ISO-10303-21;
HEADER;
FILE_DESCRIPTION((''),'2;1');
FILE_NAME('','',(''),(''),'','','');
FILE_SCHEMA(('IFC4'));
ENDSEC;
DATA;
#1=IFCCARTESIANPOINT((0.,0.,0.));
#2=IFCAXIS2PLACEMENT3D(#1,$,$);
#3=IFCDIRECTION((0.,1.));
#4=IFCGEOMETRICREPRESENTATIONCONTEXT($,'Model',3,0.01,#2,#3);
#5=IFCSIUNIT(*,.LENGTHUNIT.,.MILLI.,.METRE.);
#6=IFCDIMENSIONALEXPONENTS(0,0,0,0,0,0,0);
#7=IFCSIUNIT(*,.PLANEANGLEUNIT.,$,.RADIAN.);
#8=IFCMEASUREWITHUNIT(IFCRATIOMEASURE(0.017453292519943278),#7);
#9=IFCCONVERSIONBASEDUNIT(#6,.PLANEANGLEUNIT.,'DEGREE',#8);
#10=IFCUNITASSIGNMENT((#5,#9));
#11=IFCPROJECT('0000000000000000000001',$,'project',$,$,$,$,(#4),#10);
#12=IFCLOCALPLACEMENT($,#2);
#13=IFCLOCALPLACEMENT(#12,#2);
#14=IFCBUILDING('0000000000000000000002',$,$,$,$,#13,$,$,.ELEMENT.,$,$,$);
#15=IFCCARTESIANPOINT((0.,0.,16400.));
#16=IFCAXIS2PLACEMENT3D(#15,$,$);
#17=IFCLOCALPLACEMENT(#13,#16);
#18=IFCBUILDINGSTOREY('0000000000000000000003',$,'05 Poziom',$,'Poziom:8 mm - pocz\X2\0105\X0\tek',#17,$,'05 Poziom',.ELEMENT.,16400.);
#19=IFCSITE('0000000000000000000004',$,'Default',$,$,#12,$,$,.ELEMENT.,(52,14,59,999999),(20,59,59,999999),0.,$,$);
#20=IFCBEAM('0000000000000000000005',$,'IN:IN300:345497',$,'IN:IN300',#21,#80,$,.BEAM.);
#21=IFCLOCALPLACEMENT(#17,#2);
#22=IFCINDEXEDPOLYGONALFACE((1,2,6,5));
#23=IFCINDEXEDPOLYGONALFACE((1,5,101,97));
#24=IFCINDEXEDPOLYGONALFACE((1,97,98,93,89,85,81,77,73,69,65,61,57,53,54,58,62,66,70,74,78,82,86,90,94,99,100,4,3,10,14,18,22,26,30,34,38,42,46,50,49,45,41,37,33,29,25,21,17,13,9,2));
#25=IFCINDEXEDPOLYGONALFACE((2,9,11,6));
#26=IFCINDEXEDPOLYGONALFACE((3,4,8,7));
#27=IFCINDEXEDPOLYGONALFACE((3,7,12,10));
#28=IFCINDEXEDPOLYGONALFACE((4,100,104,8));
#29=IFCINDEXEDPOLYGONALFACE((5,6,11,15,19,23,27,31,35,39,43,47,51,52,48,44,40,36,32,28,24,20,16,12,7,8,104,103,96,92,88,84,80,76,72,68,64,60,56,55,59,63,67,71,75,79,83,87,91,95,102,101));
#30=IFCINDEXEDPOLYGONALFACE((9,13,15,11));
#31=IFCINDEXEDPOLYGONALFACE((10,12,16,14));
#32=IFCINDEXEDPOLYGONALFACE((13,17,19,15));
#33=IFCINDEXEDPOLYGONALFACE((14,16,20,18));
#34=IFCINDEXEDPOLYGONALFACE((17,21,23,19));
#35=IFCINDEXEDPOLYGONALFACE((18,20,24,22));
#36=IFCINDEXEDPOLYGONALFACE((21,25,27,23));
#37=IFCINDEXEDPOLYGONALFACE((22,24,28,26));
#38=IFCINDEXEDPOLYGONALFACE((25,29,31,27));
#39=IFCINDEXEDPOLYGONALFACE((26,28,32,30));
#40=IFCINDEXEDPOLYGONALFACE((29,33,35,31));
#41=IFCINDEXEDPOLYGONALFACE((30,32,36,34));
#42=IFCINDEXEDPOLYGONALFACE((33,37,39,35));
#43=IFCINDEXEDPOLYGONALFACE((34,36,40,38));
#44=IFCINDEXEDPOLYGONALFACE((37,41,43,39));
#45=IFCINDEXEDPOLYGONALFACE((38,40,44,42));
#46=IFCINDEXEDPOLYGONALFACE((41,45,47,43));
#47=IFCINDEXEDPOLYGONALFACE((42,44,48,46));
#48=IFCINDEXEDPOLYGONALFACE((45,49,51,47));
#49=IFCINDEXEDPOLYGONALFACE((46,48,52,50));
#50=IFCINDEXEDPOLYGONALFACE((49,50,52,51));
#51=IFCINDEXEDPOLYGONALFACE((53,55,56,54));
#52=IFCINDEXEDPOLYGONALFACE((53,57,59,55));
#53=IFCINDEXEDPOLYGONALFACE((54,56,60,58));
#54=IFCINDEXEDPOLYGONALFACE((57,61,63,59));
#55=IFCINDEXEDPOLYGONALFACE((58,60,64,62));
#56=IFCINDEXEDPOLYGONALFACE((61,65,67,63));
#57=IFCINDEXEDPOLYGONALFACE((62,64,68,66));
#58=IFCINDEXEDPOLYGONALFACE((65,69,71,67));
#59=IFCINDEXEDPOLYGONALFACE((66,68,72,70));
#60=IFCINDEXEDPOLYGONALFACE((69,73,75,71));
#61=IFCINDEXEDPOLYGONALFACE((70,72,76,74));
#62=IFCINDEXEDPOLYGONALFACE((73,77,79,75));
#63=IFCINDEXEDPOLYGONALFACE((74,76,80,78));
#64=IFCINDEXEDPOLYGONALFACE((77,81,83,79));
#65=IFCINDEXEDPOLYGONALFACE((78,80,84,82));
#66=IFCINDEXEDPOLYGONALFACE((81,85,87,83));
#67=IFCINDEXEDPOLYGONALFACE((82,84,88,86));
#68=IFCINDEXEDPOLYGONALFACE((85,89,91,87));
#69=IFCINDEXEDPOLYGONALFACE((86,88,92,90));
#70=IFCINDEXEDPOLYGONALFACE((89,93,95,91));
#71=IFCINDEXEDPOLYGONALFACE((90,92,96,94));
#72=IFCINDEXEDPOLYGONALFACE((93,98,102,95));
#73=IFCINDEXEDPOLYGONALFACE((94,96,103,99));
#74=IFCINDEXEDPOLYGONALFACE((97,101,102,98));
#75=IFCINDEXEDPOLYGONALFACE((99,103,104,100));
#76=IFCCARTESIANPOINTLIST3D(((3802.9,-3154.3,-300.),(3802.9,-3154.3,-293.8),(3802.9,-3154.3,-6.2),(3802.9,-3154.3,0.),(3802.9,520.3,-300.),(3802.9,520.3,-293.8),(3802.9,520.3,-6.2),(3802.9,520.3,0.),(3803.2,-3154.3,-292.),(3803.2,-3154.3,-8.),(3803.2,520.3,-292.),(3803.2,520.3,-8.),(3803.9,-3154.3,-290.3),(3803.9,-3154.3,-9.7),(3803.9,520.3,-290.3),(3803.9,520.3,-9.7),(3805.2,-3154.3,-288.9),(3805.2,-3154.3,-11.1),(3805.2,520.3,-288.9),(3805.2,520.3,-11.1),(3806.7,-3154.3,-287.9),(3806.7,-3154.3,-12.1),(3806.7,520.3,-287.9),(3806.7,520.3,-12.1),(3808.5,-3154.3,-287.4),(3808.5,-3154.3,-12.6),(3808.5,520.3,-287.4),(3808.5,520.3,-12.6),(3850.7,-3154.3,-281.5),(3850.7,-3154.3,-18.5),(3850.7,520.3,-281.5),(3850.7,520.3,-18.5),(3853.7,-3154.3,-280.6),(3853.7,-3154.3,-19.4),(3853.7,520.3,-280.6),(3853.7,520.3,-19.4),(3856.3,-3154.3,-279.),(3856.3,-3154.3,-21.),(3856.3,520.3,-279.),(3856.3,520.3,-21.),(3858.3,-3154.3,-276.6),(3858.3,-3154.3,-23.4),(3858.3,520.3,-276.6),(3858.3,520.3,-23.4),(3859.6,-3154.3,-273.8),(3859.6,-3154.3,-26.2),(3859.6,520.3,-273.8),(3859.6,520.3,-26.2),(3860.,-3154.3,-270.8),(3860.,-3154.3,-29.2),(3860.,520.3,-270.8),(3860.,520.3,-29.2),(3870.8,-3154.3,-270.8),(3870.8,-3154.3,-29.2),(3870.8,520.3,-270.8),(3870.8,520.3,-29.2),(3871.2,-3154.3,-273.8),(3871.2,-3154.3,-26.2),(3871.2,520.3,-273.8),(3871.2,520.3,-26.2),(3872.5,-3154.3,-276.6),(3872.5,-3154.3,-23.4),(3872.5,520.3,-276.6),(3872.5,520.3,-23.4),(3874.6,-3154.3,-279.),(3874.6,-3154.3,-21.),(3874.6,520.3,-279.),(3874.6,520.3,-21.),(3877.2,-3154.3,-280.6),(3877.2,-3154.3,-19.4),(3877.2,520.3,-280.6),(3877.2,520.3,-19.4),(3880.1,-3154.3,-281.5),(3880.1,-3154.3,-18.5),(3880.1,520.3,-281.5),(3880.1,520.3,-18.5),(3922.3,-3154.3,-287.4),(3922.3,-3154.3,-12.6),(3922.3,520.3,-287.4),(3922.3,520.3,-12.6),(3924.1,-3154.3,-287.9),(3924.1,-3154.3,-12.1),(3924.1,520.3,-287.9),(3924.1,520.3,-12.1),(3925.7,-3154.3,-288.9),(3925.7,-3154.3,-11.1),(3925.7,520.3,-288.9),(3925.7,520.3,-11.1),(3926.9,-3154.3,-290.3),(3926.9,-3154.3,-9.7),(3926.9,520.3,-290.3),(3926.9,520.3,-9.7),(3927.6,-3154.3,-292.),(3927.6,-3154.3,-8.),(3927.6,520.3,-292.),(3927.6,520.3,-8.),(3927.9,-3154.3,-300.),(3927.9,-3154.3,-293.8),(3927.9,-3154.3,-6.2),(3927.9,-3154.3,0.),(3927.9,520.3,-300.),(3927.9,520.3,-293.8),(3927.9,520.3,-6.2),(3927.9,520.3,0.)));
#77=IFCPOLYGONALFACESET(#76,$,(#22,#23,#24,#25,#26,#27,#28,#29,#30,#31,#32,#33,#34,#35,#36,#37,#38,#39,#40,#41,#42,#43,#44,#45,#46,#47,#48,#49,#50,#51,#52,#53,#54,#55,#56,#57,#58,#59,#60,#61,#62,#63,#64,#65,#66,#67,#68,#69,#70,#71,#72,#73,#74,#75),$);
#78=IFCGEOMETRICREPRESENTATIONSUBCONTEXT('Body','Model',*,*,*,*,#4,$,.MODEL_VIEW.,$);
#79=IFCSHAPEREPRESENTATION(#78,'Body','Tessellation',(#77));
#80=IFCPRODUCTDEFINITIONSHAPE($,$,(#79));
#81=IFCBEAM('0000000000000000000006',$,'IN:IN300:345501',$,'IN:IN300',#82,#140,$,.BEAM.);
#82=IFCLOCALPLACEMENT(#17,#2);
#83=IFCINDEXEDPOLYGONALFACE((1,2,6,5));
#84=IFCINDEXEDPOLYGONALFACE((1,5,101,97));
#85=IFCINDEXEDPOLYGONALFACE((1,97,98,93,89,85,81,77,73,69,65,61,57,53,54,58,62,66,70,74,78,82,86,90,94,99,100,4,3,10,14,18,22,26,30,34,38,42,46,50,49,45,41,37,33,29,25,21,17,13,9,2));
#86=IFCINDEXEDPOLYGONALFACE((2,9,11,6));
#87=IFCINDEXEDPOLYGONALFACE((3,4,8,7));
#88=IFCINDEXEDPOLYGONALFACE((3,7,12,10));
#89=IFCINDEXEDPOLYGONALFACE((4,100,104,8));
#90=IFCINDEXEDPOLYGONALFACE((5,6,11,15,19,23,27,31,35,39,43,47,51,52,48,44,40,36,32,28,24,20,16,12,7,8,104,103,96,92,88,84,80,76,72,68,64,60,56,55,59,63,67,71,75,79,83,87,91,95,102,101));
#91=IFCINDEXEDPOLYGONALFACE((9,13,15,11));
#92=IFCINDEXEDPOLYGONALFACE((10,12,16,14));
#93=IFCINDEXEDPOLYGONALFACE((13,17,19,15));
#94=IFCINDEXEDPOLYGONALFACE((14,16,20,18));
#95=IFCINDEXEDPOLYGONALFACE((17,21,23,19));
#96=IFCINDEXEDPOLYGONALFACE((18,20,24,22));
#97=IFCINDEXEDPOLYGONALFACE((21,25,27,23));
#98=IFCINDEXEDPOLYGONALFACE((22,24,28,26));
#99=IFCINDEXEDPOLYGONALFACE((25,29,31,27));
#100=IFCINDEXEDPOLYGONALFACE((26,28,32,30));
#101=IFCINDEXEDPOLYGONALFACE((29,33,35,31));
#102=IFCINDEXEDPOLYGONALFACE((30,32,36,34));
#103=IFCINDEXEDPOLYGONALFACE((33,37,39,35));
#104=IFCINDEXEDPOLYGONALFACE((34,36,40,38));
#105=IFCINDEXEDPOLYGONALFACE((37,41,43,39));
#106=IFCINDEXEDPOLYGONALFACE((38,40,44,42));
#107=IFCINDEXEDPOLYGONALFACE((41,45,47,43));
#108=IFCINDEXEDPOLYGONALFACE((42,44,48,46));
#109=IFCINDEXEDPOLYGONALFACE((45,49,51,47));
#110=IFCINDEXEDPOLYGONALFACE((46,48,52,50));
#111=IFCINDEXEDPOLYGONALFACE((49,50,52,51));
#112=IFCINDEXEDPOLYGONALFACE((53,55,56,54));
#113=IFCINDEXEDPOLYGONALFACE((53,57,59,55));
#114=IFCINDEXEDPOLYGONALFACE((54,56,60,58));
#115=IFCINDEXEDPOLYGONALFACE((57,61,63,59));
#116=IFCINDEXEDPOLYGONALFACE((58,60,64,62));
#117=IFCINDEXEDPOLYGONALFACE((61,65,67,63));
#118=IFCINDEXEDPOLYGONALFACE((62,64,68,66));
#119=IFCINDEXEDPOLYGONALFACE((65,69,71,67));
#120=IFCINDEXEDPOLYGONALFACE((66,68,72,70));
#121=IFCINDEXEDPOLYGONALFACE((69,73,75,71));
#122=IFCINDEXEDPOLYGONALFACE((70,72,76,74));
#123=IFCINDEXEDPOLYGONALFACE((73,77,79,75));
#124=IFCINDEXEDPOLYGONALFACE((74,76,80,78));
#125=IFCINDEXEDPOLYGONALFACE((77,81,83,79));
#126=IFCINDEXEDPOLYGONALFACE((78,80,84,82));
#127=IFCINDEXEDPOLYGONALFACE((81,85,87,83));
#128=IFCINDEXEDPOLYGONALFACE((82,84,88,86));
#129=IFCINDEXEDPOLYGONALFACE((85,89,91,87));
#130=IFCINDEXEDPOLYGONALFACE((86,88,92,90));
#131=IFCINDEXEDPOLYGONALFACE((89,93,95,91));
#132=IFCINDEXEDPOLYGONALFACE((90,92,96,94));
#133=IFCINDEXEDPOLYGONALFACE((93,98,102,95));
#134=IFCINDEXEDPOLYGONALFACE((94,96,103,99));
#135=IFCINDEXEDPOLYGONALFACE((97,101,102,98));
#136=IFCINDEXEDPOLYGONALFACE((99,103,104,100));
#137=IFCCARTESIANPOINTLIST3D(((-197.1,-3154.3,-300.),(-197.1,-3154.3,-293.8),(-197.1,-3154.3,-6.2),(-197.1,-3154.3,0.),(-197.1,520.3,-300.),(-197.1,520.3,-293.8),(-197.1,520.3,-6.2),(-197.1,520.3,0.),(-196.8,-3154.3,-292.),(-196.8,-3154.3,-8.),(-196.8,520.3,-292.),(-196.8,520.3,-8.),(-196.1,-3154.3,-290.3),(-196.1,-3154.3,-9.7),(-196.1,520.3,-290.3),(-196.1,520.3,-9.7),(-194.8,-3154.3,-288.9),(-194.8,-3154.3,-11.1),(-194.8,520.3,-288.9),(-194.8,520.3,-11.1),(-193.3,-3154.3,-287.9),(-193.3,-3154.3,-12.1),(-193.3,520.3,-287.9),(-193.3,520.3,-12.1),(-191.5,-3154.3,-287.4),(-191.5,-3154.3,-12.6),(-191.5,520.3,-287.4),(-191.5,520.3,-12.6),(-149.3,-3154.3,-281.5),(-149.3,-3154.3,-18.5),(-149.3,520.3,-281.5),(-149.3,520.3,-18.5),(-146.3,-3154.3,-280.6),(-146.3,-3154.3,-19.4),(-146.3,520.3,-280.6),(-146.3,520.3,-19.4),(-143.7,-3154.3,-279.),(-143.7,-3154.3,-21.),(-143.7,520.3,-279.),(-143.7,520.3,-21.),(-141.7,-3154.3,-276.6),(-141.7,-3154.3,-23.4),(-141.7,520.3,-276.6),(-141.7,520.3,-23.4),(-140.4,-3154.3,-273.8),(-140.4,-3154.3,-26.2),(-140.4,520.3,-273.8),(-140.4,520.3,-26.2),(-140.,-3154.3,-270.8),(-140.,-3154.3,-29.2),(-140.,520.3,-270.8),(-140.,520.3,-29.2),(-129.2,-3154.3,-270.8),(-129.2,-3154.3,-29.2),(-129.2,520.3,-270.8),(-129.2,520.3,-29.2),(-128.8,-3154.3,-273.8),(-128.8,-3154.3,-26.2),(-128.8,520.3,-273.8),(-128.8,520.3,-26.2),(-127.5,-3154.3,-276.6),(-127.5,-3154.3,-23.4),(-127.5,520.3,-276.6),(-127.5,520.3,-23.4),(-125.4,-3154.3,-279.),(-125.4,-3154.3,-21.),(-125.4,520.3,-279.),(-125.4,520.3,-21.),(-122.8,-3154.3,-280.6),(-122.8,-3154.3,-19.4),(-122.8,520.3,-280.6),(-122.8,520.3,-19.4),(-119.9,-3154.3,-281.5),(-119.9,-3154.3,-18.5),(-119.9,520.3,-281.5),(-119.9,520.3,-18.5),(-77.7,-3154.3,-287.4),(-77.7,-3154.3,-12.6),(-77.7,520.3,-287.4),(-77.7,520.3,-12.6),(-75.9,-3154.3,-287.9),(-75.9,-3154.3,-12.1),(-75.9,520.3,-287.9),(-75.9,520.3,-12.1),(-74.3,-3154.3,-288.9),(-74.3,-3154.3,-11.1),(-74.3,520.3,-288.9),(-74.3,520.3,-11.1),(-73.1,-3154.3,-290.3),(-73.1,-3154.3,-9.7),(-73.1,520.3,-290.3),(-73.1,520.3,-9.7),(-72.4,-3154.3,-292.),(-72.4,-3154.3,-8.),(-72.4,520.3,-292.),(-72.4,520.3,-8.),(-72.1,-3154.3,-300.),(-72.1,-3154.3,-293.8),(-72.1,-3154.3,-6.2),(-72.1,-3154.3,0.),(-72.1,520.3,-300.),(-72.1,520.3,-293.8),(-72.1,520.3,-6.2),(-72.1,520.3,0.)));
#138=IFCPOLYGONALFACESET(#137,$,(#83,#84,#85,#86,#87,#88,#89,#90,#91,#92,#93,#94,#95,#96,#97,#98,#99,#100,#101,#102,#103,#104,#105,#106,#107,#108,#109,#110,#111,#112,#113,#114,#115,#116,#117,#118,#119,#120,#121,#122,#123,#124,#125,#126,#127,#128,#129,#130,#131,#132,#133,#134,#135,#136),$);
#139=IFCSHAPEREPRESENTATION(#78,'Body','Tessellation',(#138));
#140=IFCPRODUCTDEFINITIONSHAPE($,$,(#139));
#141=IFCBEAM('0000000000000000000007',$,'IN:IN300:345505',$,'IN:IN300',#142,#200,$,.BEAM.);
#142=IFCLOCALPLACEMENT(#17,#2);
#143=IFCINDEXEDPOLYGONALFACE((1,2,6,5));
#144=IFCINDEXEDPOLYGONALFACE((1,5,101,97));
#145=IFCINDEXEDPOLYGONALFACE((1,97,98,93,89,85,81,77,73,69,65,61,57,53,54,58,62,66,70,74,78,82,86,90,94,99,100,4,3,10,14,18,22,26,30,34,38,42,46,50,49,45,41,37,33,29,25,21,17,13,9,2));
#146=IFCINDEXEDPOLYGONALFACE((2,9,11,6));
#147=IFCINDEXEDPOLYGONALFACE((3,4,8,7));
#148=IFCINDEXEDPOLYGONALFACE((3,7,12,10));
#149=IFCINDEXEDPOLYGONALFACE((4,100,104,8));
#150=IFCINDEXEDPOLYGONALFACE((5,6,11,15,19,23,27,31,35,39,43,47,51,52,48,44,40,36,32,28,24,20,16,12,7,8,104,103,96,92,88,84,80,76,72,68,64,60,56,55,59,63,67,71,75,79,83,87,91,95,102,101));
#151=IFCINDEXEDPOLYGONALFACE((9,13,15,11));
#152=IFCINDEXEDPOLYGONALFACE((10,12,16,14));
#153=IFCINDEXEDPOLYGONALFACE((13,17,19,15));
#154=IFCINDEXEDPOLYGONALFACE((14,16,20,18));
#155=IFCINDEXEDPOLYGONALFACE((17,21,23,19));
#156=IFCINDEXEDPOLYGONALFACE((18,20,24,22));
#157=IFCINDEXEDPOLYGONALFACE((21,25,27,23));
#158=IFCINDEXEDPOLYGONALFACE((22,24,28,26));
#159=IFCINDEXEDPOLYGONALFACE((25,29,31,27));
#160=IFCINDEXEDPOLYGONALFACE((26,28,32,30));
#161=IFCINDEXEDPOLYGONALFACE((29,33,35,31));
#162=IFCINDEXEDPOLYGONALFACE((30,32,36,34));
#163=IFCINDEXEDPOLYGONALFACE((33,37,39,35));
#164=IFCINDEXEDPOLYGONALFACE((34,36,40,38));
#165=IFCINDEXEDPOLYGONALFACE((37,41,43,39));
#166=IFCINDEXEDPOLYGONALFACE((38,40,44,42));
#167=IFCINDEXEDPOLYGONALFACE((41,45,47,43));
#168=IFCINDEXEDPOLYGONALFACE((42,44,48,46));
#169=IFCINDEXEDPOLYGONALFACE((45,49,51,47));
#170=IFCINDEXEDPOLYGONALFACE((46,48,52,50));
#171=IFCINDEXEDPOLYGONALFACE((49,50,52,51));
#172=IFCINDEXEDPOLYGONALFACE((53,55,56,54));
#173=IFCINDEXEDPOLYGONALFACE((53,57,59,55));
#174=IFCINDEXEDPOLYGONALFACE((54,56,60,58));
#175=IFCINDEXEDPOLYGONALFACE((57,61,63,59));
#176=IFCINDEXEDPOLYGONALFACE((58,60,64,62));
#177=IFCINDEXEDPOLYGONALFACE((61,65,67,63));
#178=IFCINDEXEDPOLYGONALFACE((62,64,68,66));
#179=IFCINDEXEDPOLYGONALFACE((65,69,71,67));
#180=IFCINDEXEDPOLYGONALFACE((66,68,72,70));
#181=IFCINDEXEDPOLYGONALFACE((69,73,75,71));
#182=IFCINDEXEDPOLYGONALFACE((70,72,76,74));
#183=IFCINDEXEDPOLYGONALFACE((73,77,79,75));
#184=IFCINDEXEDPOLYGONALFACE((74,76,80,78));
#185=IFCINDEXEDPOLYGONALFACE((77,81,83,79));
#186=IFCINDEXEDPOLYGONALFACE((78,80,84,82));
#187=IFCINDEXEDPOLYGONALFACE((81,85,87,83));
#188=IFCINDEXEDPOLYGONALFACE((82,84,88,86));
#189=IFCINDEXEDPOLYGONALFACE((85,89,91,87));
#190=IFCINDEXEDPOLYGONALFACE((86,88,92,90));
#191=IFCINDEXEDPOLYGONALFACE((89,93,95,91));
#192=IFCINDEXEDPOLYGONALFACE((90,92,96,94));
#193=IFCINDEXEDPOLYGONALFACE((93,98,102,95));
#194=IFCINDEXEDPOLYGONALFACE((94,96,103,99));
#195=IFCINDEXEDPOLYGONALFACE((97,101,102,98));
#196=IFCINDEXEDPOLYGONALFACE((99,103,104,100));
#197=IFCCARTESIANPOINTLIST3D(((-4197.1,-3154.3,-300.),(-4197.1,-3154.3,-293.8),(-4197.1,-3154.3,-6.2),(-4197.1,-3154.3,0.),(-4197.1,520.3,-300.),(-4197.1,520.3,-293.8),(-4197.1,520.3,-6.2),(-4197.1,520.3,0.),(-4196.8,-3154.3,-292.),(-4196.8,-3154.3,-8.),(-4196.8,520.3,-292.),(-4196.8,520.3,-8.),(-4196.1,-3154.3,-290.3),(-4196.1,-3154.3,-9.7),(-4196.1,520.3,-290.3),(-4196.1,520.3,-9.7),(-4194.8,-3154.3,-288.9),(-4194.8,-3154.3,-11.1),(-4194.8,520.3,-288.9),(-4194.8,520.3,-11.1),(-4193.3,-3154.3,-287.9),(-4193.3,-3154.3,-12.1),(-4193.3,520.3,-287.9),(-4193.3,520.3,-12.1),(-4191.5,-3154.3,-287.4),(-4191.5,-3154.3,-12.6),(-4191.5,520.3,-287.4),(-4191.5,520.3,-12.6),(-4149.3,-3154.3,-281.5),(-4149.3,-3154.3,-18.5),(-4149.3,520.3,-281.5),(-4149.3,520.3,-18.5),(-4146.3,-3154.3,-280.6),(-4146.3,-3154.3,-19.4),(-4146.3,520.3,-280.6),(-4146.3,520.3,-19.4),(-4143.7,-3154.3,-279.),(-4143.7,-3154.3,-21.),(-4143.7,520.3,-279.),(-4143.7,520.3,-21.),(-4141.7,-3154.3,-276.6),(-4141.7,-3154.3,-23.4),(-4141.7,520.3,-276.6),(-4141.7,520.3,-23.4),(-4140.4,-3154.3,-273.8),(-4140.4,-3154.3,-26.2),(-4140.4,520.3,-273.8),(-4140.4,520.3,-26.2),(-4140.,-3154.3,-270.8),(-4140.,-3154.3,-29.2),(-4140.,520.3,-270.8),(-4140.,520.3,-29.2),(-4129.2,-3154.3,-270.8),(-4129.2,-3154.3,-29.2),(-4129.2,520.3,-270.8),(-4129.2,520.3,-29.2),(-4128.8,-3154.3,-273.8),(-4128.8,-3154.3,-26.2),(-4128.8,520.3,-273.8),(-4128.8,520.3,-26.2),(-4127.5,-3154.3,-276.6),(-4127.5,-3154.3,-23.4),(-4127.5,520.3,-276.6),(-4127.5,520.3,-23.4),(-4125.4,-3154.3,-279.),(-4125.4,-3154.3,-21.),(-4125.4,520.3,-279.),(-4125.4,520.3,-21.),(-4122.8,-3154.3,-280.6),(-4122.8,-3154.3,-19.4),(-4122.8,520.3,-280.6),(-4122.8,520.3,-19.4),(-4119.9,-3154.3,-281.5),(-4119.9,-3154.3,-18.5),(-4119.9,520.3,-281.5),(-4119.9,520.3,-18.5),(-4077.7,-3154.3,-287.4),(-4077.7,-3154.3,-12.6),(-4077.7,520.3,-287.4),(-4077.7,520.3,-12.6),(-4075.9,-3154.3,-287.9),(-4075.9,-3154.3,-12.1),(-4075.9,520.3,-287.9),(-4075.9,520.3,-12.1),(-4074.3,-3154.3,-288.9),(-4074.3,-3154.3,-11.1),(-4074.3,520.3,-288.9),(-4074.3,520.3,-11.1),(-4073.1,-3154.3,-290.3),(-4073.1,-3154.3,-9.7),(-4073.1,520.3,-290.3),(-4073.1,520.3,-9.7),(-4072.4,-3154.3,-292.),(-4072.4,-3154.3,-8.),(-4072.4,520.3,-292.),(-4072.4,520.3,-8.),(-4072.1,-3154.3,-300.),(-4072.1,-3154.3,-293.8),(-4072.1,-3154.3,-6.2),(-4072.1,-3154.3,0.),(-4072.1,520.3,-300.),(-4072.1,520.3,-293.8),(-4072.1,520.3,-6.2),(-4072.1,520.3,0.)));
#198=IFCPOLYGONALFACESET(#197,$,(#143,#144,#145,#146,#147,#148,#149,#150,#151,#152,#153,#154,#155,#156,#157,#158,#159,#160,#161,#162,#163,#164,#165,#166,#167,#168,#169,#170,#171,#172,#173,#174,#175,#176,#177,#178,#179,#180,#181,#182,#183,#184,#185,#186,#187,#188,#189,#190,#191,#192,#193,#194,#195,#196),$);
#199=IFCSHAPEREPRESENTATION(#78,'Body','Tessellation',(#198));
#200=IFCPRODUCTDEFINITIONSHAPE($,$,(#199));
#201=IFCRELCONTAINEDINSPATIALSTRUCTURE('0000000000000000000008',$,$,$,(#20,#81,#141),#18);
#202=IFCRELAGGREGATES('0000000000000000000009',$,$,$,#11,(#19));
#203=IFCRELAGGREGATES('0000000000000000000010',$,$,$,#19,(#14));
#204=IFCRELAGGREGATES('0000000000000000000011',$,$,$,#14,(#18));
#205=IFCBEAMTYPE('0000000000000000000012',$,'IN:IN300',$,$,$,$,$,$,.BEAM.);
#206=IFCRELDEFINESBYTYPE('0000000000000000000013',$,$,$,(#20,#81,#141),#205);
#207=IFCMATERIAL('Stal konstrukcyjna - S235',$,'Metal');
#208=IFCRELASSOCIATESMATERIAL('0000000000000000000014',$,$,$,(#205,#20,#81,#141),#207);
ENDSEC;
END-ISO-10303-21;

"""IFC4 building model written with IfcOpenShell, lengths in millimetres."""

from ifc_helpers import new_model, entity, si_unit, converted_unit, direction, frame, origin, place, context, subcontext, project, spatial, line, arc, indexed_curve, outline, extrude, source, transform, mapped, material, type_object, type_shapes, element, save


model = new_model("IFC4")

# Units and contexts
model_context = context("Model", 3, precision=0.01, world=origin(), true_north=direction((0.0, 1.0)))
body_context = subcontext(model_context, "Body", "Model", "MODEL_VIEW")
ifc_project = project(units=[si_unit("LENGTHUNIT", "METRE", prefix="MILLI"), converted_unit("PLANEANGLEUNIT", "DEGREE", entity("IfcRatioMeasure", 0.017453292519943278), si_unit("PLANEANGLEUNIT", "RADIAN"), dimensions=[0, 0, 0, 0, 0, 0, 0])], contexts=[model_context])

# Site, building, storey
site_placement = place(None, origin())
site = spatial("IfcSite", under=ifc_project, at=site_placement, Name="Default", CompositionType="ELEMENT", RefLatitude=(52, 14, 59, 999999), RefLongitude=(20, 59, 59, 999999), RefElevation=0.0)
building_placement = place(site_placement, origin())
building = spatial("IfcBuilding", under=site, at=building_placement, CompositionType="ELEMENT")
storey_placement = place(building_placement, frame((0.0, 0.0, 16400.0)))
storey = spatial("IfcBuildingStorey", under=building, at=storey_placement, Name="05 Poziom", ObjectType="Poziom:8 mm - początek", LongName="05 Poziom", CompositionType="ELEMENT", Elevation=16400.0)

# Shared definitions
ifc_material = material(Name="Stal konstrukcyjna - S235", Category="Metal")

# Beams
beam_type_1 = type_object("IfcBeamType", Name="IN:IN300", PredefinedType="BEAM", material=ifc_material)
shared_shape_1 = source(origin(), body_context, "Body", "SweptSolid", [
    extrude(outline(indexed_curve([(143.8, -62.5), (150.0, -62.5), (150.0, 62.5), (143.8, 62.5), (139.6, 60.9), (137.4, 56.9), (131.5, 14.7), (127.9, 8.1), (120.8, 5.4), (-120.8, 5.4), (-127.9, 8.1), (-131.5, 14.7), (-137.4, 56.9), (-139.6, 60.9), (-143.8, 62.5), (-150.0, 62.5), (-150.0, -62.5), (-143.8, -62.5), (-139.6, -60.9), (-137.4, -56.9), (-131.5, -14.7), (-127.9, -8.1), (-120.8, -5.4), (120.8, -5.4), (127.9, -8.1), (131.5, -14.7), (137.4, -56.9), (139.6, -60.9)], segments=[line(1, 2, 3, 4), arc(4, 5, 6), line(6, 7), arc(7, 8, 9), line(9, 10), arc(10, 11, 12), line(12, 13), arc(13, 14, 15), line(15, 16, 17, 18), arc(18, 19, 20), line(20, 21), arc(21, 22, 23), line(23, 24), arc(24, 25, 26), line(26, 27), arc(27, 28, 1)], self_intersect=False)), frame((-1837.3, 0.0, 0.0), z_axis=(1.0, 0.0, 0.0), x_axis=(0.0, 0.0, -1.0)), (0.0, 0.0, 1.0), 3674.6),
])
type_shapes(beam_type_1, [shared_shape_1])
for number, where, z_axis, x_axis, name in (
    (1, (3865.4, -1317.0, -150.0), (0.0, 0.0, 1.0), (0.0, -1.0, 0.0), "IN:IN300:345497"),
    (2, (-134.6, -1317.0, -150.0), (0.0, 0.0, 1.0), (0.0, -1.0, 0.0), "IN:IN300:345501"),
    (3, (-4134.6, -1317.0, -150.0), (0.0, 0.0, 1.0), (0.0, -1.0, 0.0), "IN:IN300:345505"),
):
    element("IfcBeam", number, at=place(storey_placement, frame(where, z_axis=z_axis, x_axis=x_axis)), inside=storey, type_object=beam_type_1, material=ifc_material, Name=name, ObjectType="IN:IN300", PredefinedType="BEAM", context=body_context, shape_type="MappedRepresentation", body=[
        mapped(shared_shape_1, transform((0.0, 0.0, 0.0), scale=1.0)),
    ])

save(model, "model.ifc")
